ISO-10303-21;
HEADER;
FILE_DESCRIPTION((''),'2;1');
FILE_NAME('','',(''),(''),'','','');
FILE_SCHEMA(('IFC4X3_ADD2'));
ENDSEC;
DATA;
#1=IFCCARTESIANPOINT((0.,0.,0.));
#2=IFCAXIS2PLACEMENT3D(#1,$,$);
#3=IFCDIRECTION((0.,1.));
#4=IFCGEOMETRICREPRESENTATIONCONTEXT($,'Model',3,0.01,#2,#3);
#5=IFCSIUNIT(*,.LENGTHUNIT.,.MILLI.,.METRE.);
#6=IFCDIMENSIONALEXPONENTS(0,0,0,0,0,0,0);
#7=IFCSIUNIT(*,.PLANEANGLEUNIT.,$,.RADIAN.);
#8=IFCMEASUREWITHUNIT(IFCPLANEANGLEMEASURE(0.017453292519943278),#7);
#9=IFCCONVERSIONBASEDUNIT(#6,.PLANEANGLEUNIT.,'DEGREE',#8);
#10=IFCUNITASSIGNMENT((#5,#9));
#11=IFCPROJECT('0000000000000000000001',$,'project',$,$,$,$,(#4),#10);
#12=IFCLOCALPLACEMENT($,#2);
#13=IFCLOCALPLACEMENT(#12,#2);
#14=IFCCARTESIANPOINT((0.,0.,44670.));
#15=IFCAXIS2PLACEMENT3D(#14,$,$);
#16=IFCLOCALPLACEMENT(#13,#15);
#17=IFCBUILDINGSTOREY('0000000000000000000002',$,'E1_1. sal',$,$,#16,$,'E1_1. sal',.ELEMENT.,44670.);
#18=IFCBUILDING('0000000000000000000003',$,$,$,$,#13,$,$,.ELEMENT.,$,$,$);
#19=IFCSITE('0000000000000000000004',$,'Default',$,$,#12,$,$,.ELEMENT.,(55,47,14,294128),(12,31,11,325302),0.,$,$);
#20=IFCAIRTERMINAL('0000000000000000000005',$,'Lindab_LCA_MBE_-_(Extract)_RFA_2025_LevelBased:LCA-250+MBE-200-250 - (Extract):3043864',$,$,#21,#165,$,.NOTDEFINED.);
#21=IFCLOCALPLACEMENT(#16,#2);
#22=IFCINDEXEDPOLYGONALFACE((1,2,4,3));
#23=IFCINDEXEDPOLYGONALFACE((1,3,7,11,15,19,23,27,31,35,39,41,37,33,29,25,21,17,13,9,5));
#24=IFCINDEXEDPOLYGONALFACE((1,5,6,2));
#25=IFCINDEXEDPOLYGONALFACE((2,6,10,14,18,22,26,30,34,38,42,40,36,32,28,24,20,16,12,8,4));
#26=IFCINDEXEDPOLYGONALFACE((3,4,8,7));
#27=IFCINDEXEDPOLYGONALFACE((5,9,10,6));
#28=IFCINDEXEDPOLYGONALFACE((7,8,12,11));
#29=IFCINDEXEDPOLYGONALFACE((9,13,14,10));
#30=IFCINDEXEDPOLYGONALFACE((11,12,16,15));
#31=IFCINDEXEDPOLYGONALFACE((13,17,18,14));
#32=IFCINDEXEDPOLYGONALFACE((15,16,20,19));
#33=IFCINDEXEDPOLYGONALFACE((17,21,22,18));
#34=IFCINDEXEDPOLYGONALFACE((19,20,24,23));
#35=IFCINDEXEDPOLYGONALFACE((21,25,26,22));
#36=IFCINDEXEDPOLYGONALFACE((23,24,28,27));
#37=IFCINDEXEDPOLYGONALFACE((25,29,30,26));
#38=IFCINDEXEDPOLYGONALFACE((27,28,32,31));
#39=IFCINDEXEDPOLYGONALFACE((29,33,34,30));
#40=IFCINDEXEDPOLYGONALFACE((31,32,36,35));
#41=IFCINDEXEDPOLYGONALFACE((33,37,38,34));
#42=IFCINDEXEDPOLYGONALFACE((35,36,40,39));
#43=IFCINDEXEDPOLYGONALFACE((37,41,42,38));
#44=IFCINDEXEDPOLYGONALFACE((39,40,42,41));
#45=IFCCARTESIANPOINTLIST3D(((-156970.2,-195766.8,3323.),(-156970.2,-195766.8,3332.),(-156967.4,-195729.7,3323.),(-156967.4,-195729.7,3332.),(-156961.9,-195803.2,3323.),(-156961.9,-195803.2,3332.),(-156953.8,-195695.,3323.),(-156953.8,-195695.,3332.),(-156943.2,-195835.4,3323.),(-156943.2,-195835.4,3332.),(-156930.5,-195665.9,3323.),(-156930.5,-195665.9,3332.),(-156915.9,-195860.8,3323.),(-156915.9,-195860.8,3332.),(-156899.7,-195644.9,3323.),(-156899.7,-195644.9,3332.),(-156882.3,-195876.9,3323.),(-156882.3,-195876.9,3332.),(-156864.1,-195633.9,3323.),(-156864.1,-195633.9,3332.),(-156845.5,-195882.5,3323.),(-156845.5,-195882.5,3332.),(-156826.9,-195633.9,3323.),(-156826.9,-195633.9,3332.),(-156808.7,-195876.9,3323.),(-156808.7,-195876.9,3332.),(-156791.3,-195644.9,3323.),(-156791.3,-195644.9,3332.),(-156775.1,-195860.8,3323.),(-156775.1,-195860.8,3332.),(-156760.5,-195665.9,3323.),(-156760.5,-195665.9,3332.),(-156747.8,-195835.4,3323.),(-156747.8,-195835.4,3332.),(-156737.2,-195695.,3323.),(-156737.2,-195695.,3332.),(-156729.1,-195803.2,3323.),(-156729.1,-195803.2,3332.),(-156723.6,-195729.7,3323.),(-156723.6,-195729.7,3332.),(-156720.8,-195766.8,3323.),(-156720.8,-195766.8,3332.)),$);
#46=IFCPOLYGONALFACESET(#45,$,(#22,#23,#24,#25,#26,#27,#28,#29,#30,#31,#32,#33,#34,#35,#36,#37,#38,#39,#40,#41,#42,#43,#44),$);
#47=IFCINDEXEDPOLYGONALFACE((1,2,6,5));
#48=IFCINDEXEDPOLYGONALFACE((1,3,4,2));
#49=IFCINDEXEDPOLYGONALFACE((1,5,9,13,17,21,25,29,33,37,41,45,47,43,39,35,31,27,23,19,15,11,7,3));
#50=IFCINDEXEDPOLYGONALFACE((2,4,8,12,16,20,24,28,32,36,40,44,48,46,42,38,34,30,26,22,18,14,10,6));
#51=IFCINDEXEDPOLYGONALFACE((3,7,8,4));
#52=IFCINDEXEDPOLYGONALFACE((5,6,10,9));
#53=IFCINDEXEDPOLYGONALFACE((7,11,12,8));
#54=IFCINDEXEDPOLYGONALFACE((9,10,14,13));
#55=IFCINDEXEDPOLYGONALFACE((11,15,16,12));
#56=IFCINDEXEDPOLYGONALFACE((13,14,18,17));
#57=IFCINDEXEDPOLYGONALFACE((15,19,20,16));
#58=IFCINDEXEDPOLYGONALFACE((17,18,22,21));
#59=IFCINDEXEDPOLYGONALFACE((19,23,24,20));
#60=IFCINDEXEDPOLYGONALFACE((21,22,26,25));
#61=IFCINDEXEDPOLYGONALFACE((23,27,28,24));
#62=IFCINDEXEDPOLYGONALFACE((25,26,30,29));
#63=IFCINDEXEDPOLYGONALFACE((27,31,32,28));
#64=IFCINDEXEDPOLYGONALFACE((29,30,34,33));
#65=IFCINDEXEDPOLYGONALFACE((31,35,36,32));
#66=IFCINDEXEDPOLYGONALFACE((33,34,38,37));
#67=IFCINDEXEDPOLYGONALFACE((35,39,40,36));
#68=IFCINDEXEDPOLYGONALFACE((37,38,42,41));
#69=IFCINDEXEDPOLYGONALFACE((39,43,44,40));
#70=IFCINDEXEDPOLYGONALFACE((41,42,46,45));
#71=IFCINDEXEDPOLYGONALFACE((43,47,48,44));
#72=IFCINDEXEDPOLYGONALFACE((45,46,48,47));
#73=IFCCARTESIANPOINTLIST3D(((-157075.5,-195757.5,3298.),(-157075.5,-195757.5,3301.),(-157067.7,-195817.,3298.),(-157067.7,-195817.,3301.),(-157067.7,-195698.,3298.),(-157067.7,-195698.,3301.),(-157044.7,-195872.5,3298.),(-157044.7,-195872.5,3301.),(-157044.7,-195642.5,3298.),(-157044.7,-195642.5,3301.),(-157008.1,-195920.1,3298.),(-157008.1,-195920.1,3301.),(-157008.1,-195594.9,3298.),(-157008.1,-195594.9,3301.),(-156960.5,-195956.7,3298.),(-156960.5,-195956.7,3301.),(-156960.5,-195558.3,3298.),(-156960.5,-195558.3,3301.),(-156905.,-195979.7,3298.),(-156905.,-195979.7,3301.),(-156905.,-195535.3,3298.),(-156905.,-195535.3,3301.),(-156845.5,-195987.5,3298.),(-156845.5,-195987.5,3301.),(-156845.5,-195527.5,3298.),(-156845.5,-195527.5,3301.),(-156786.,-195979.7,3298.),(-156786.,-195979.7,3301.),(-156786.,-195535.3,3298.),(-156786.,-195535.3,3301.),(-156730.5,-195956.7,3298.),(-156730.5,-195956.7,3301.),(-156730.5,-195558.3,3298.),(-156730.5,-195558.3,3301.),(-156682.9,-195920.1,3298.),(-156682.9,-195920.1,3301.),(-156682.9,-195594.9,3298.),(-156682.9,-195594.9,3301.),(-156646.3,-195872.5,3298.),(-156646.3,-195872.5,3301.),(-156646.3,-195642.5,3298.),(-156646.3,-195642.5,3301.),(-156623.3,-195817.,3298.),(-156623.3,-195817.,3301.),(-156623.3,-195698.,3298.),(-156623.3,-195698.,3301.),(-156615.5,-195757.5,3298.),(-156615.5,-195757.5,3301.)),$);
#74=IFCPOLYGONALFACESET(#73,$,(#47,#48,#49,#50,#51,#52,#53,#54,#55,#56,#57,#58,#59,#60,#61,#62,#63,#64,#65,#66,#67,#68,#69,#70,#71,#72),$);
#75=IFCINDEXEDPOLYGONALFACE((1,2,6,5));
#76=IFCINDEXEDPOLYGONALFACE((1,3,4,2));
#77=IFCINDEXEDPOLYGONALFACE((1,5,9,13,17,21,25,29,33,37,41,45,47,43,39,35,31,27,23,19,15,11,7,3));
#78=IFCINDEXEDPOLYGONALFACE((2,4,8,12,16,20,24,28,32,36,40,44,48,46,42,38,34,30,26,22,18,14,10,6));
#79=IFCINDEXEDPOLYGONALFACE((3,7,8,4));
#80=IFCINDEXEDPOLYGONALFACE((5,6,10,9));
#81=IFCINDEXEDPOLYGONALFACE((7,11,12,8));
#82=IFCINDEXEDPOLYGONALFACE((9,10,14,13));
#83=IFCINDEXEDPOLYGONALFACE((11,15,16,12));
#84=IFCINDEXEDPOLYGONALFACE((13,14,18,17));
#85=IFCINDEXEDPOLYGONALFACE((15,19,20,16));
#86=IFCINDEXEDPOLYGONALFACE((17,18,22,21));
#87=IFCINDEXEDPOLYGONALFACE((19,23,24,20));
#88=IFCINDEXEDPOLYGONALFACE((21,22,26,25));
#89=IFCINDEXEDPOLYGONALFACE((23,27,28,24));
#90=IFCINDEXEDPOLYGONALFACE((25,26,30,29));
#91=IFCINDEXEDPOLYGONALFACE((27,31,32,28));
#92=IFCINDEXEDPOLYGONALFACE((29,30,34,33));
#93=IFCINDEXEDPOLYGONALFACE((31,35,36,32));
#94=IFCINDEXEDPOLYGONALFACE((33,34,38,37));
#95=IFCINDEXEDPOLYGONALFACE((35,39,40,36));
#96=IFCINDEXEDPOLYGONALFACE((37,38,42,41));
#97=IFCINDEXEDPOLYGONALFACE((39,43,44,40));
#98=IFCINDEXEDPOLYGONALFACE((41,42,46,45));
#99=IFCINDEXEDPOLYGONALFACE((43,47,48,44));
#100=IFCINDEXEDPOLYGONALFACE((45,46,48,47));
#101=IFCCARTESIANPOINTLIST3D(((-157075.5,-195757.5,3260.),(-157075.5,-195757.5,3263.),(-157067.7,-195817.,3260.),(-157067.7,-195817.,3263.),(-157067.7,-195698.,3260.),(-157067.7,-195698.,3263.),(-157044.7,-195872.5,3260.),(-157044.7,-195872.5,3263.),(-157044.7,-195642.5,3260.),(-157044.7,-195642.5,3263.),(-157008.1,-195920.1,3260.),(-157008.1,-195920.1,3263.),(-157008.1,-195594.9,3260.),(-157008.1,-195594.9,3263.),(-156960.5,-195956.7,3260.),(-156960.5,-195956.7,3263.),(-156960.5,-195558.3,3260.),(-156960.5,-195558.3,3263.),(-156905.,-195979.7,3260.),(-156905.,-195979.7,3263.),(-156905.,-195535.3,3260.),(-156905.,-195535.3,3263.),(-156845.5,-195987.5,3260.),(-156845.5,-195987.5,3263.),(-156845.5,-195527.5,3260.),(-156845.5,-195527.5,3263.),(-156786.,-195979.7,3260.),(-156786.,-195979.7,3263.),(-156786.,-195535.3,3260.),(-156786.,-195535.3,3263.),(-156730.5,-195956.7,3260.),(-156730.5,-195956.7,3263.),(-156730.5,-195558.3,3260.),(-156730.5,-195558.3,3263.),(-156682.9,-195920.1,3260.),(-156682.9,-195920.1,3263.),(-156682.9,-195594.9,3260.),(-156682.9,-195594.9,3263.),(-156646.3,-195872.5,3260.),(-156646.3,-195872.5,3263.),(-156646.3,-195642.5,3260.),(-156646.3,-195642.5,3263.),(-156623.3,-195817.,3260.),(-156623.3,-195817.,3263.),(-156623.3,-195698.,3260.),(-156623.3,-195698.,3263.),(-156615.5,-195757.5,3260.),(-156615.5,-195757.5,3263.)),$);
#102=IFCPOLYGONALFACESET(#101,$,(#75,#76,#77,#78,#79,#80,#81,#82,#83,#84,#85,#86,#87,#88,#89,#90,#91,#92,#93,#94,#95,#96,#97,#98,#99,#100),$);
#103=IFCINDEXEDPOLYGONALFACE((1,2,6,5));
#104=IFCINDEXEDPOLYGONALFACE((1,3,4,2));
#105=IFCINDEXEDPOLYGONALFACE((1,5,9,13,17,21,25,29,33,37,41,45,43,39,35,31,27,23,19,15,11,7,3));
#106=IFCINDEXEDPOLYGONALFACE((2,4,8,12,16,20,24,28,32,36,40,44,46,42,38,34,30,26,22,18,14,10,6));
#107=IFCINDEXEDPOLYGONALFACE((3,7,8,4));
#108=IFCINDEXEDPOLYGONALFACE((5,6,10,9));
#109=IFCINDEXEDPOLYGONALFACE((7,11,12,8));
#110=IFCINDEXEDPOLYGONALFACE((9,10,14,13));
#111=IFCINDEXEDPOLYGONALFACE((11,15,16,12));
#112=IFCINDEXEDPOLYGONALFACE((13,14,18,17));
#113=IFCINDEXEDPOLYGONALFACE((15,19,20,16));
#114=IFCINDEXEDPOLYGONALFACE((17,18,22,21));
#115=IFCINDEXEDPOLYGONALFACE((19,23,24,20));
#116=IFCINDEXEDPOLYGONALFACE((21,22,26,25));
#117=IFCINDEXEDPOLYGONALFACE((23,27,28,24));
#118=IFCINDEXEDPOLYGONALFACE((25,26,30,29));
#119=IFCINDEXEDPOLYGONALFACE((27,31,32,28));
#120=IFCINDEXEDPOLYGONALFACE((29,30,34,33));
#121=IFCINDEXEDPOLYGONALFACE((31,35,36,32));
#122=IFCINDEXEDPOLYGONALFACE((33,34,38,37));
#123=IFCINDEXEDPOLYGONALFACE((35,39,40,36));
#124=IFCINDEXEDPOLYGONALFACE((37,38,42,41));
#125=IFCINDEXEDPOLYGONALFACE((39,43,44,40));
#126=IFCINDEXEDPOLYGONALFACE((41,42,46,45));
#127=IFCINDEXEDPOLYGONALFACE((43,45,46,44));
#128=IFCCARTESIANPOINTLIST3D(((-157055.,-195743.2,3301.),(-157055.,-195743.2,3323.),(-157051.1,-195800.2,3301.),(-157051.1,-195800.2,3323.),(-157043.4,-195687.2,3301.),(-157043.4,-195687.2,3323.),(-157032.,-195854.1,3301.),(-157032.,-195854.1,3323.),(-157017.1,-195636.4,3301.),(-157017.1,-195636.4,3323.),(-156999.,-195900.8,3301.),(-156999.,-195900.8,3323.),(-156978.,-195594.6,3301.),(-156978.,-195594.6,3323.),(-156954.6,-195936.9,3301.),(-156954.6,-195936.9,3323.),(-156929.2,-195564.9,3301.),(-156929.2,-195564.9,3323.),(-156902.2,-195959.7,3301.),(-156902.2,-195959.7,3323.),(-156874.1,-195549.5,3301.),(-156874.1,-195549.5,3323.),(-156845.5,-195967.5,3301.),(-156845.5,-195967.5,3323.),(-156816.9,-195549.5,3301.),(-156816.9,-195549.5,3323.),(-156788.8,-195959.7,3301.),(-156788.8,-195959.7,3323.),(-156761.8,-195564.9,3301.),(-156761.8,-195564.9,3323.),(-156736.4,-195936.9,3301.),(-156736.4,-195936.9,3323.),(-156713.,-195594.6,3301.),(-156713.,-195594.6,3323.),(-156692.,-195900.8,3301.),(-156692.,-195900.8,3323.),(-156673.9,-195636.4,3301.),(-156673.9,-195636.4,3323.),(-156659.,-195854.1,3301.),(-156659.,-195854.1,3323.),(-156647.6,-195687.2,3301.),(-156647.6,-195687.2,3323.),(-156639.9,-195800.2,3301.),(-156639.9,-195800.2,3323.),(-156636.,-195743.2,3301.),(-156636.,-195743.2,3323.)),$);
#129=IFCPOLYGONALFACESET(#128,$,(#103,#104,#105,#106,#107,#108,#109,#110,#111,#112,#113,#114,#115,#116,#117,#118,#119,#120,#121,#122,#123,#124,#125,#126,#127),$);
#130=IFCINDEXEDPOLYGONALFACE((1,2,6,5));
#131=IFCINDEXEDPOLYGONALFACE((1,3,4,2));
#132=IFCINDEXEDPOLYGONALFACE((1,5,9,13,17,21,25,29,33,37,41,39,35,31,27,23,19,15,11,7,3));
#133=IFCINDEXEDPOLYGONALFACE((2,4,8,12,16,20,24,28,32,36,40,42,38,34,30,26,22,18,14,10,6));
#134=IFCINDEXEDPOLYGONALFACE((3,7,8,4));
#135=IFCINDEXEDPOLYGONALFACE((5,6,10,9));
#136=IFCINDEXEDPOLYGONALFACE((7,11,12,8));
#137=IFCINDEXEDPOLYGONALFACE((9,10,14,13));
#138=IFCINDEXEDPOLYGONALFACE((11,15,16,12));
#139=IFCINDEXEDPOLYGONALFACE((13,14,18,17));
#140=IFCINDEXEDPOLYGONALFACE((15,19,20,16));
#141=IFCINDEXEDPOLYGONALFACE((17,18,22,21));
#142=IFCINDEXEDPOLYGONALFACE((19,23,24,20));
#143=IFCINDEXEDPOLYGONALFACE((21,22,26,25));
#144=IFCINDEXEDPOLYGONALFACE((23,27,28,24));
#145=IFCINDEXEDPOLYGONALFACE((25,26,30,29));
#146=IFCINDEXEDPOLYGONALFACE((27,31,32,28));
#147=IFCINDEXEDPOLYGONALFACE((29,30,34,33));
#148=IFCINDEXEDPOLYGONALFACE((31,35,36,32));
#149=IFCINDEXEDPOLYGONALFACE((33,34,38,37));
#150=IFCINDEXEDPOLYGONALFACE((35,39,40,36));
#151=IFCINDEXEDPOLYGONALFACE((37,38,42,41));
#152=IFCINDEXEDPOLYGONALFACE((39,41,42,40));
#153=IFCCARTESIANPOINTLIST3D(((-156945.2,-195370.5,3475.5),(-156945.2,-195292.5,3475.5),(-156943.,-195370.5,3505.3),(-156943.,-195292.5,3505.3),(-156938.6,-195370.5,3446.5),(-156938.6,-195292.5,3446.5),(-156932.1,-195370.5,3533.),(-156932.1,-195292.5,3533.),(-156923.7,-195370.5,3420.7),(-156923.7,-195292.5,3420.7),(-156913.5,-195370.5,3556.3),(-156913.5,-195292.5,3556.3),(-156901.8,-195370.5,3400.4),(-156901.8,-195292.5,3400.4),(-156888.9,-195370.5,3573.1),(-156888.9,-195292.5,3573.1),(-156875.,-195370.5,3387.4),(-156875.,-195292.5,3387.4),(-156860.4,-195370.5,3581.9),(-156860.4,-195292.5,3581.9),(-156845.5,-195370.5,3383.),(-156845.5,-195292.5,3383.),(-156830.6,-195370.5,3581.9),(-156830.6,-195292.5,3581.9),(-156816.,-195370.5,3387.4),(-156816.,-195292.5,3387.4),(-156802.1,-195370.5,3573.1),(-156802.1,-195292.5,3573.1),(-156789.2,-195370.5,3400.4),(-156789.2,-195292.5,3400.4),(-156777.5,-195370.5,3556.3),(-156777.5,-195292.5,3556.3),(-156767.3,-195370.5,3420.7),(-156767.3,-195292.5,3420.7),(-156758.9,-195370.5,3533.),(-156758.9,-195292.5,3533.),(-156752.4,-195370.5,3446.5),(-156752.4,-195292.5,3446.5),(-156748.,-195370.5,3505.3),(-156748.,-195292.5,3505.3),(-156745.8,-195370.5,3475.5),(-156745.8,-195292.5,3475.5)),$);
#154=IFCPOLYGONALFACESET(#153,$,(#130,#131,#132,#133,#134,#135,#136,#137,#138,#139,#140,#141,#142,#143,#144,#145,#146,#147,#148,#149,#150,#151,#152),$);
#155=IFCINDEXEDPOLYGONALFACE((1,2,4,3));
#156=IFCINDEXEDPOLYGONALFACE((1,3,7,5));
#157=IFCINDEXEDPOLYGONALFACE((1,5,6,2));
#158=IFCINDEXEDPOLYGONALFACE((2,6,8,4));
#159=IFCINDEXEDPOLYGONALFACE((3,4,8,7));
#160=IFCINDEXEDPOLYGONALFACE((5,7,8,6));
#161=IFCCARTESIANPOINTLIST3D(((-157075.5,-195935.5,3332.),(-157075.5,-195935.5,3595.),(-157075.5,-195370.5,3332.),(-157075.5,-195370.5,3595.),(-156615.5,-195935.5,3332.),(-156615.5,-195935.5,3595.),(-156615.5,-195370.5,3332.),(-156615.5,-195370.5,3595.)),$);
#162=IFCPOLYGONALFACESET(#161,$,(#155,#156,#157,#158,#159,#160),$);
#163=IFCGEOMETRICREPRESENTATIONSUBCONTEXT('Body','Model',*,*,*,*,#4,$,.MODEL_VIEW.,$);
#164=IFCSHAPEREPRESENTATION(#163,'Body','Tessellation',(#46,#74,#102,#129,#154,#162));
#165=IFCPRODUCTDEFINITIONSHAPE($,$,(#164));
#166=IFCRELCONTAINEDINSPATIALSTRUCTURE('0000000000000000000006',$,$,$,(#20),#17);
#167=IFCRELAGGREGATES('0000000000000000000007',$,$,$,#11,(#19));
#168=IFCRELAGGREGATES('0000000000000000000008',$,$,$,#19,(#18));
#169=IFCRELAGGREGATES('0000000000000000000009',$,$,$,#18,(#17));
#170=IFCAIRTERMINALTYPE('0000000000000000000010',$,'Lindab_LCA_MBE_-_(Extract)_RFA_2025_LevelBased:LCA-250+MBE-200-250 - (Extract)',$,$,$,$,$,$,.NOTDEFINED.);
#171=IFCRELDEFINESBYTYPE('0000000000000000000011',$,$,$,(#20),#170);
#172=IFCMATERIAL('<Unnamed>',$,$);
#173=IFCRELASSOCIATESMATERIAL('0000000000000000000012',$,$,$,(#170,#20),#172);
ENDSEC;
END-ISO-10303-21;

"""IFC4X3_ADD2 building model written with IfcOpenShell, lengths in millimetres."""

from ifc_helpers import new_model, entity, si_unit, converted_unit, direction, frame, frame_2d, origin, origin_2d_with_axis, place, context, subcontext, project, spatial, rectangle, circle, extrude, source, transform, mapped, material, type_object, type_shapes, element, save


model = new_model("IFC4X3_ADD2")

# Units and contexts
model_context = context("Model", 3, precision=0.01, world=origin(), true_north=direction((0.0, 1.0)))
body_context = subcontext(model_context, "Body", "Model", "MODEL_VIEW")
ifc_project = project(units=[si_unit("LENGTHUNIT", "METRE", prefix="MILLI"), converted_unit("PLANEANGLEUNIT", "DEGREE", entity("IfcPlaneAngleMeasure", 0.017453292519943278), si_unit("PLANEANGLEUNIT", "RADIAN"), dimensions=[0, 0, 0, 0, 0, 0, 0])], contexts=[model_context])

# Site, building, storey
site_placement = place(None, origin())
site = spatial("IfcSite", under=ifc_project, at=site_placement, Name="Default", CompositionType="ELEMENT", RefLatitude=(55, 47, 14, 294128), RefLongitude=(12, 31, 11, 325302), RefElevation=0.0)
building_placement = place(site_placement, origin())
building = spatial("IfcBuilding", under=site, at=building_placement, CompositionType="ELEMENT")
storey_placement = place(building_placement, frame((0.0, 0.0, 44670.0)))
storey = spatial("IfcBuildingStorey", under=building, at=storey_placement, Name="E1_1. sal", LongName="E1_1. sal", CompositionType="ELEMENT", Elevation=44670.0)

# Air terminal
ifc_material_1 = material(Name="<Unnamed>")
air_terminal_type_1 = type_object("IfcAirTerminalType", Name="Lindab_LCA_MBE_-_(Extract)_RFA_2025_LevelBased:LCA-250+MBE-200-250 - (Extract)", PredefinedType="NOTDEFINED", material=ifc_material_1)
shared_shape_1 = source(origin(), body_context, "Body", "SweptSolid", [
    extrude(circle(Radius=125.0, at=frame_2d((0.0, 0.0), x_axis=(1.0, 0.0))), frame((0.0, 0.0, 22.0)), (0.0, 0.0, 1.0), 9.0),
    extrude(circle(Radius=230.0, at=frame_2d((0.0, 0.0), x_axis=(1.0, 0.0))), frame((0.0, 0.0, -3.0)), (0.0, 0.0, 1.0), 3.0),
    extrude(circle(Radius=230.0, at=frame_2d((0.0, 0.0), x_axis=(1.0, 0.0))), frame((0.0, 0.0, -41.0)), (0.0, 0.0, 1.0), 3.0),
    extrude(circle(Radius=210.0, at=frame_2d((0.0, 0.0), x_axis=(1.0, 0.0))), origin(), (0.0, 0.0, 1.0), 22.0),
    extrude(circle(Radius=100.0, at=frame_2d((0.0, 0.0), x_axis=(1.0, 0.0))), frame((-465.0, 0.0, 182.0), z_axis=(1.0, 0.0, 0.0), x_axis=(0.0, 0.0, -1.0)), (0.0, 0.0, 1.0), 78.0),
    extrude(rectangle(XDim=460.0, YDim=565.0, at=origin_2d_with_axis()), frame((-104.5, 0.0, 31.0), z_axis=(0.0, 0.0, 1.0), x_axis=(0.0, -1.0, 0.0)), (0.0, 0.0, 1.0), 263.0),
])
type_shapes(air_terminal_type_1, [shared_shape_1])
for number, where, z_axis, x_axis, name in (
    (1, (-156845.5, -195757.5, 3301.0), (0.0, 0.0, 1.0), (0.0, -1.0, 0.0), "Lindab_LCA_MBE_-_(Extract)_RFA_2025_LevelBased:LCA-250+MBE-200-250 - (Extract):3043864"),
):
    element("IfcAirTerminal", number, at=place(storey_placement, frame(where, z_axis=z_axis, x_axis=x_axis)), inside=storey, type_object=air_terminal_type_1, material=ifc_material_1, Name=name, PredefinedType="NOTDEFINED", context=body_context, shape_type="MappedRepresentation", body=[
        mapped(shared_shape_1, transform((0.0, 0.0, 0.0), scale=1.0)),
    ])

save(model, "model.ifc")
